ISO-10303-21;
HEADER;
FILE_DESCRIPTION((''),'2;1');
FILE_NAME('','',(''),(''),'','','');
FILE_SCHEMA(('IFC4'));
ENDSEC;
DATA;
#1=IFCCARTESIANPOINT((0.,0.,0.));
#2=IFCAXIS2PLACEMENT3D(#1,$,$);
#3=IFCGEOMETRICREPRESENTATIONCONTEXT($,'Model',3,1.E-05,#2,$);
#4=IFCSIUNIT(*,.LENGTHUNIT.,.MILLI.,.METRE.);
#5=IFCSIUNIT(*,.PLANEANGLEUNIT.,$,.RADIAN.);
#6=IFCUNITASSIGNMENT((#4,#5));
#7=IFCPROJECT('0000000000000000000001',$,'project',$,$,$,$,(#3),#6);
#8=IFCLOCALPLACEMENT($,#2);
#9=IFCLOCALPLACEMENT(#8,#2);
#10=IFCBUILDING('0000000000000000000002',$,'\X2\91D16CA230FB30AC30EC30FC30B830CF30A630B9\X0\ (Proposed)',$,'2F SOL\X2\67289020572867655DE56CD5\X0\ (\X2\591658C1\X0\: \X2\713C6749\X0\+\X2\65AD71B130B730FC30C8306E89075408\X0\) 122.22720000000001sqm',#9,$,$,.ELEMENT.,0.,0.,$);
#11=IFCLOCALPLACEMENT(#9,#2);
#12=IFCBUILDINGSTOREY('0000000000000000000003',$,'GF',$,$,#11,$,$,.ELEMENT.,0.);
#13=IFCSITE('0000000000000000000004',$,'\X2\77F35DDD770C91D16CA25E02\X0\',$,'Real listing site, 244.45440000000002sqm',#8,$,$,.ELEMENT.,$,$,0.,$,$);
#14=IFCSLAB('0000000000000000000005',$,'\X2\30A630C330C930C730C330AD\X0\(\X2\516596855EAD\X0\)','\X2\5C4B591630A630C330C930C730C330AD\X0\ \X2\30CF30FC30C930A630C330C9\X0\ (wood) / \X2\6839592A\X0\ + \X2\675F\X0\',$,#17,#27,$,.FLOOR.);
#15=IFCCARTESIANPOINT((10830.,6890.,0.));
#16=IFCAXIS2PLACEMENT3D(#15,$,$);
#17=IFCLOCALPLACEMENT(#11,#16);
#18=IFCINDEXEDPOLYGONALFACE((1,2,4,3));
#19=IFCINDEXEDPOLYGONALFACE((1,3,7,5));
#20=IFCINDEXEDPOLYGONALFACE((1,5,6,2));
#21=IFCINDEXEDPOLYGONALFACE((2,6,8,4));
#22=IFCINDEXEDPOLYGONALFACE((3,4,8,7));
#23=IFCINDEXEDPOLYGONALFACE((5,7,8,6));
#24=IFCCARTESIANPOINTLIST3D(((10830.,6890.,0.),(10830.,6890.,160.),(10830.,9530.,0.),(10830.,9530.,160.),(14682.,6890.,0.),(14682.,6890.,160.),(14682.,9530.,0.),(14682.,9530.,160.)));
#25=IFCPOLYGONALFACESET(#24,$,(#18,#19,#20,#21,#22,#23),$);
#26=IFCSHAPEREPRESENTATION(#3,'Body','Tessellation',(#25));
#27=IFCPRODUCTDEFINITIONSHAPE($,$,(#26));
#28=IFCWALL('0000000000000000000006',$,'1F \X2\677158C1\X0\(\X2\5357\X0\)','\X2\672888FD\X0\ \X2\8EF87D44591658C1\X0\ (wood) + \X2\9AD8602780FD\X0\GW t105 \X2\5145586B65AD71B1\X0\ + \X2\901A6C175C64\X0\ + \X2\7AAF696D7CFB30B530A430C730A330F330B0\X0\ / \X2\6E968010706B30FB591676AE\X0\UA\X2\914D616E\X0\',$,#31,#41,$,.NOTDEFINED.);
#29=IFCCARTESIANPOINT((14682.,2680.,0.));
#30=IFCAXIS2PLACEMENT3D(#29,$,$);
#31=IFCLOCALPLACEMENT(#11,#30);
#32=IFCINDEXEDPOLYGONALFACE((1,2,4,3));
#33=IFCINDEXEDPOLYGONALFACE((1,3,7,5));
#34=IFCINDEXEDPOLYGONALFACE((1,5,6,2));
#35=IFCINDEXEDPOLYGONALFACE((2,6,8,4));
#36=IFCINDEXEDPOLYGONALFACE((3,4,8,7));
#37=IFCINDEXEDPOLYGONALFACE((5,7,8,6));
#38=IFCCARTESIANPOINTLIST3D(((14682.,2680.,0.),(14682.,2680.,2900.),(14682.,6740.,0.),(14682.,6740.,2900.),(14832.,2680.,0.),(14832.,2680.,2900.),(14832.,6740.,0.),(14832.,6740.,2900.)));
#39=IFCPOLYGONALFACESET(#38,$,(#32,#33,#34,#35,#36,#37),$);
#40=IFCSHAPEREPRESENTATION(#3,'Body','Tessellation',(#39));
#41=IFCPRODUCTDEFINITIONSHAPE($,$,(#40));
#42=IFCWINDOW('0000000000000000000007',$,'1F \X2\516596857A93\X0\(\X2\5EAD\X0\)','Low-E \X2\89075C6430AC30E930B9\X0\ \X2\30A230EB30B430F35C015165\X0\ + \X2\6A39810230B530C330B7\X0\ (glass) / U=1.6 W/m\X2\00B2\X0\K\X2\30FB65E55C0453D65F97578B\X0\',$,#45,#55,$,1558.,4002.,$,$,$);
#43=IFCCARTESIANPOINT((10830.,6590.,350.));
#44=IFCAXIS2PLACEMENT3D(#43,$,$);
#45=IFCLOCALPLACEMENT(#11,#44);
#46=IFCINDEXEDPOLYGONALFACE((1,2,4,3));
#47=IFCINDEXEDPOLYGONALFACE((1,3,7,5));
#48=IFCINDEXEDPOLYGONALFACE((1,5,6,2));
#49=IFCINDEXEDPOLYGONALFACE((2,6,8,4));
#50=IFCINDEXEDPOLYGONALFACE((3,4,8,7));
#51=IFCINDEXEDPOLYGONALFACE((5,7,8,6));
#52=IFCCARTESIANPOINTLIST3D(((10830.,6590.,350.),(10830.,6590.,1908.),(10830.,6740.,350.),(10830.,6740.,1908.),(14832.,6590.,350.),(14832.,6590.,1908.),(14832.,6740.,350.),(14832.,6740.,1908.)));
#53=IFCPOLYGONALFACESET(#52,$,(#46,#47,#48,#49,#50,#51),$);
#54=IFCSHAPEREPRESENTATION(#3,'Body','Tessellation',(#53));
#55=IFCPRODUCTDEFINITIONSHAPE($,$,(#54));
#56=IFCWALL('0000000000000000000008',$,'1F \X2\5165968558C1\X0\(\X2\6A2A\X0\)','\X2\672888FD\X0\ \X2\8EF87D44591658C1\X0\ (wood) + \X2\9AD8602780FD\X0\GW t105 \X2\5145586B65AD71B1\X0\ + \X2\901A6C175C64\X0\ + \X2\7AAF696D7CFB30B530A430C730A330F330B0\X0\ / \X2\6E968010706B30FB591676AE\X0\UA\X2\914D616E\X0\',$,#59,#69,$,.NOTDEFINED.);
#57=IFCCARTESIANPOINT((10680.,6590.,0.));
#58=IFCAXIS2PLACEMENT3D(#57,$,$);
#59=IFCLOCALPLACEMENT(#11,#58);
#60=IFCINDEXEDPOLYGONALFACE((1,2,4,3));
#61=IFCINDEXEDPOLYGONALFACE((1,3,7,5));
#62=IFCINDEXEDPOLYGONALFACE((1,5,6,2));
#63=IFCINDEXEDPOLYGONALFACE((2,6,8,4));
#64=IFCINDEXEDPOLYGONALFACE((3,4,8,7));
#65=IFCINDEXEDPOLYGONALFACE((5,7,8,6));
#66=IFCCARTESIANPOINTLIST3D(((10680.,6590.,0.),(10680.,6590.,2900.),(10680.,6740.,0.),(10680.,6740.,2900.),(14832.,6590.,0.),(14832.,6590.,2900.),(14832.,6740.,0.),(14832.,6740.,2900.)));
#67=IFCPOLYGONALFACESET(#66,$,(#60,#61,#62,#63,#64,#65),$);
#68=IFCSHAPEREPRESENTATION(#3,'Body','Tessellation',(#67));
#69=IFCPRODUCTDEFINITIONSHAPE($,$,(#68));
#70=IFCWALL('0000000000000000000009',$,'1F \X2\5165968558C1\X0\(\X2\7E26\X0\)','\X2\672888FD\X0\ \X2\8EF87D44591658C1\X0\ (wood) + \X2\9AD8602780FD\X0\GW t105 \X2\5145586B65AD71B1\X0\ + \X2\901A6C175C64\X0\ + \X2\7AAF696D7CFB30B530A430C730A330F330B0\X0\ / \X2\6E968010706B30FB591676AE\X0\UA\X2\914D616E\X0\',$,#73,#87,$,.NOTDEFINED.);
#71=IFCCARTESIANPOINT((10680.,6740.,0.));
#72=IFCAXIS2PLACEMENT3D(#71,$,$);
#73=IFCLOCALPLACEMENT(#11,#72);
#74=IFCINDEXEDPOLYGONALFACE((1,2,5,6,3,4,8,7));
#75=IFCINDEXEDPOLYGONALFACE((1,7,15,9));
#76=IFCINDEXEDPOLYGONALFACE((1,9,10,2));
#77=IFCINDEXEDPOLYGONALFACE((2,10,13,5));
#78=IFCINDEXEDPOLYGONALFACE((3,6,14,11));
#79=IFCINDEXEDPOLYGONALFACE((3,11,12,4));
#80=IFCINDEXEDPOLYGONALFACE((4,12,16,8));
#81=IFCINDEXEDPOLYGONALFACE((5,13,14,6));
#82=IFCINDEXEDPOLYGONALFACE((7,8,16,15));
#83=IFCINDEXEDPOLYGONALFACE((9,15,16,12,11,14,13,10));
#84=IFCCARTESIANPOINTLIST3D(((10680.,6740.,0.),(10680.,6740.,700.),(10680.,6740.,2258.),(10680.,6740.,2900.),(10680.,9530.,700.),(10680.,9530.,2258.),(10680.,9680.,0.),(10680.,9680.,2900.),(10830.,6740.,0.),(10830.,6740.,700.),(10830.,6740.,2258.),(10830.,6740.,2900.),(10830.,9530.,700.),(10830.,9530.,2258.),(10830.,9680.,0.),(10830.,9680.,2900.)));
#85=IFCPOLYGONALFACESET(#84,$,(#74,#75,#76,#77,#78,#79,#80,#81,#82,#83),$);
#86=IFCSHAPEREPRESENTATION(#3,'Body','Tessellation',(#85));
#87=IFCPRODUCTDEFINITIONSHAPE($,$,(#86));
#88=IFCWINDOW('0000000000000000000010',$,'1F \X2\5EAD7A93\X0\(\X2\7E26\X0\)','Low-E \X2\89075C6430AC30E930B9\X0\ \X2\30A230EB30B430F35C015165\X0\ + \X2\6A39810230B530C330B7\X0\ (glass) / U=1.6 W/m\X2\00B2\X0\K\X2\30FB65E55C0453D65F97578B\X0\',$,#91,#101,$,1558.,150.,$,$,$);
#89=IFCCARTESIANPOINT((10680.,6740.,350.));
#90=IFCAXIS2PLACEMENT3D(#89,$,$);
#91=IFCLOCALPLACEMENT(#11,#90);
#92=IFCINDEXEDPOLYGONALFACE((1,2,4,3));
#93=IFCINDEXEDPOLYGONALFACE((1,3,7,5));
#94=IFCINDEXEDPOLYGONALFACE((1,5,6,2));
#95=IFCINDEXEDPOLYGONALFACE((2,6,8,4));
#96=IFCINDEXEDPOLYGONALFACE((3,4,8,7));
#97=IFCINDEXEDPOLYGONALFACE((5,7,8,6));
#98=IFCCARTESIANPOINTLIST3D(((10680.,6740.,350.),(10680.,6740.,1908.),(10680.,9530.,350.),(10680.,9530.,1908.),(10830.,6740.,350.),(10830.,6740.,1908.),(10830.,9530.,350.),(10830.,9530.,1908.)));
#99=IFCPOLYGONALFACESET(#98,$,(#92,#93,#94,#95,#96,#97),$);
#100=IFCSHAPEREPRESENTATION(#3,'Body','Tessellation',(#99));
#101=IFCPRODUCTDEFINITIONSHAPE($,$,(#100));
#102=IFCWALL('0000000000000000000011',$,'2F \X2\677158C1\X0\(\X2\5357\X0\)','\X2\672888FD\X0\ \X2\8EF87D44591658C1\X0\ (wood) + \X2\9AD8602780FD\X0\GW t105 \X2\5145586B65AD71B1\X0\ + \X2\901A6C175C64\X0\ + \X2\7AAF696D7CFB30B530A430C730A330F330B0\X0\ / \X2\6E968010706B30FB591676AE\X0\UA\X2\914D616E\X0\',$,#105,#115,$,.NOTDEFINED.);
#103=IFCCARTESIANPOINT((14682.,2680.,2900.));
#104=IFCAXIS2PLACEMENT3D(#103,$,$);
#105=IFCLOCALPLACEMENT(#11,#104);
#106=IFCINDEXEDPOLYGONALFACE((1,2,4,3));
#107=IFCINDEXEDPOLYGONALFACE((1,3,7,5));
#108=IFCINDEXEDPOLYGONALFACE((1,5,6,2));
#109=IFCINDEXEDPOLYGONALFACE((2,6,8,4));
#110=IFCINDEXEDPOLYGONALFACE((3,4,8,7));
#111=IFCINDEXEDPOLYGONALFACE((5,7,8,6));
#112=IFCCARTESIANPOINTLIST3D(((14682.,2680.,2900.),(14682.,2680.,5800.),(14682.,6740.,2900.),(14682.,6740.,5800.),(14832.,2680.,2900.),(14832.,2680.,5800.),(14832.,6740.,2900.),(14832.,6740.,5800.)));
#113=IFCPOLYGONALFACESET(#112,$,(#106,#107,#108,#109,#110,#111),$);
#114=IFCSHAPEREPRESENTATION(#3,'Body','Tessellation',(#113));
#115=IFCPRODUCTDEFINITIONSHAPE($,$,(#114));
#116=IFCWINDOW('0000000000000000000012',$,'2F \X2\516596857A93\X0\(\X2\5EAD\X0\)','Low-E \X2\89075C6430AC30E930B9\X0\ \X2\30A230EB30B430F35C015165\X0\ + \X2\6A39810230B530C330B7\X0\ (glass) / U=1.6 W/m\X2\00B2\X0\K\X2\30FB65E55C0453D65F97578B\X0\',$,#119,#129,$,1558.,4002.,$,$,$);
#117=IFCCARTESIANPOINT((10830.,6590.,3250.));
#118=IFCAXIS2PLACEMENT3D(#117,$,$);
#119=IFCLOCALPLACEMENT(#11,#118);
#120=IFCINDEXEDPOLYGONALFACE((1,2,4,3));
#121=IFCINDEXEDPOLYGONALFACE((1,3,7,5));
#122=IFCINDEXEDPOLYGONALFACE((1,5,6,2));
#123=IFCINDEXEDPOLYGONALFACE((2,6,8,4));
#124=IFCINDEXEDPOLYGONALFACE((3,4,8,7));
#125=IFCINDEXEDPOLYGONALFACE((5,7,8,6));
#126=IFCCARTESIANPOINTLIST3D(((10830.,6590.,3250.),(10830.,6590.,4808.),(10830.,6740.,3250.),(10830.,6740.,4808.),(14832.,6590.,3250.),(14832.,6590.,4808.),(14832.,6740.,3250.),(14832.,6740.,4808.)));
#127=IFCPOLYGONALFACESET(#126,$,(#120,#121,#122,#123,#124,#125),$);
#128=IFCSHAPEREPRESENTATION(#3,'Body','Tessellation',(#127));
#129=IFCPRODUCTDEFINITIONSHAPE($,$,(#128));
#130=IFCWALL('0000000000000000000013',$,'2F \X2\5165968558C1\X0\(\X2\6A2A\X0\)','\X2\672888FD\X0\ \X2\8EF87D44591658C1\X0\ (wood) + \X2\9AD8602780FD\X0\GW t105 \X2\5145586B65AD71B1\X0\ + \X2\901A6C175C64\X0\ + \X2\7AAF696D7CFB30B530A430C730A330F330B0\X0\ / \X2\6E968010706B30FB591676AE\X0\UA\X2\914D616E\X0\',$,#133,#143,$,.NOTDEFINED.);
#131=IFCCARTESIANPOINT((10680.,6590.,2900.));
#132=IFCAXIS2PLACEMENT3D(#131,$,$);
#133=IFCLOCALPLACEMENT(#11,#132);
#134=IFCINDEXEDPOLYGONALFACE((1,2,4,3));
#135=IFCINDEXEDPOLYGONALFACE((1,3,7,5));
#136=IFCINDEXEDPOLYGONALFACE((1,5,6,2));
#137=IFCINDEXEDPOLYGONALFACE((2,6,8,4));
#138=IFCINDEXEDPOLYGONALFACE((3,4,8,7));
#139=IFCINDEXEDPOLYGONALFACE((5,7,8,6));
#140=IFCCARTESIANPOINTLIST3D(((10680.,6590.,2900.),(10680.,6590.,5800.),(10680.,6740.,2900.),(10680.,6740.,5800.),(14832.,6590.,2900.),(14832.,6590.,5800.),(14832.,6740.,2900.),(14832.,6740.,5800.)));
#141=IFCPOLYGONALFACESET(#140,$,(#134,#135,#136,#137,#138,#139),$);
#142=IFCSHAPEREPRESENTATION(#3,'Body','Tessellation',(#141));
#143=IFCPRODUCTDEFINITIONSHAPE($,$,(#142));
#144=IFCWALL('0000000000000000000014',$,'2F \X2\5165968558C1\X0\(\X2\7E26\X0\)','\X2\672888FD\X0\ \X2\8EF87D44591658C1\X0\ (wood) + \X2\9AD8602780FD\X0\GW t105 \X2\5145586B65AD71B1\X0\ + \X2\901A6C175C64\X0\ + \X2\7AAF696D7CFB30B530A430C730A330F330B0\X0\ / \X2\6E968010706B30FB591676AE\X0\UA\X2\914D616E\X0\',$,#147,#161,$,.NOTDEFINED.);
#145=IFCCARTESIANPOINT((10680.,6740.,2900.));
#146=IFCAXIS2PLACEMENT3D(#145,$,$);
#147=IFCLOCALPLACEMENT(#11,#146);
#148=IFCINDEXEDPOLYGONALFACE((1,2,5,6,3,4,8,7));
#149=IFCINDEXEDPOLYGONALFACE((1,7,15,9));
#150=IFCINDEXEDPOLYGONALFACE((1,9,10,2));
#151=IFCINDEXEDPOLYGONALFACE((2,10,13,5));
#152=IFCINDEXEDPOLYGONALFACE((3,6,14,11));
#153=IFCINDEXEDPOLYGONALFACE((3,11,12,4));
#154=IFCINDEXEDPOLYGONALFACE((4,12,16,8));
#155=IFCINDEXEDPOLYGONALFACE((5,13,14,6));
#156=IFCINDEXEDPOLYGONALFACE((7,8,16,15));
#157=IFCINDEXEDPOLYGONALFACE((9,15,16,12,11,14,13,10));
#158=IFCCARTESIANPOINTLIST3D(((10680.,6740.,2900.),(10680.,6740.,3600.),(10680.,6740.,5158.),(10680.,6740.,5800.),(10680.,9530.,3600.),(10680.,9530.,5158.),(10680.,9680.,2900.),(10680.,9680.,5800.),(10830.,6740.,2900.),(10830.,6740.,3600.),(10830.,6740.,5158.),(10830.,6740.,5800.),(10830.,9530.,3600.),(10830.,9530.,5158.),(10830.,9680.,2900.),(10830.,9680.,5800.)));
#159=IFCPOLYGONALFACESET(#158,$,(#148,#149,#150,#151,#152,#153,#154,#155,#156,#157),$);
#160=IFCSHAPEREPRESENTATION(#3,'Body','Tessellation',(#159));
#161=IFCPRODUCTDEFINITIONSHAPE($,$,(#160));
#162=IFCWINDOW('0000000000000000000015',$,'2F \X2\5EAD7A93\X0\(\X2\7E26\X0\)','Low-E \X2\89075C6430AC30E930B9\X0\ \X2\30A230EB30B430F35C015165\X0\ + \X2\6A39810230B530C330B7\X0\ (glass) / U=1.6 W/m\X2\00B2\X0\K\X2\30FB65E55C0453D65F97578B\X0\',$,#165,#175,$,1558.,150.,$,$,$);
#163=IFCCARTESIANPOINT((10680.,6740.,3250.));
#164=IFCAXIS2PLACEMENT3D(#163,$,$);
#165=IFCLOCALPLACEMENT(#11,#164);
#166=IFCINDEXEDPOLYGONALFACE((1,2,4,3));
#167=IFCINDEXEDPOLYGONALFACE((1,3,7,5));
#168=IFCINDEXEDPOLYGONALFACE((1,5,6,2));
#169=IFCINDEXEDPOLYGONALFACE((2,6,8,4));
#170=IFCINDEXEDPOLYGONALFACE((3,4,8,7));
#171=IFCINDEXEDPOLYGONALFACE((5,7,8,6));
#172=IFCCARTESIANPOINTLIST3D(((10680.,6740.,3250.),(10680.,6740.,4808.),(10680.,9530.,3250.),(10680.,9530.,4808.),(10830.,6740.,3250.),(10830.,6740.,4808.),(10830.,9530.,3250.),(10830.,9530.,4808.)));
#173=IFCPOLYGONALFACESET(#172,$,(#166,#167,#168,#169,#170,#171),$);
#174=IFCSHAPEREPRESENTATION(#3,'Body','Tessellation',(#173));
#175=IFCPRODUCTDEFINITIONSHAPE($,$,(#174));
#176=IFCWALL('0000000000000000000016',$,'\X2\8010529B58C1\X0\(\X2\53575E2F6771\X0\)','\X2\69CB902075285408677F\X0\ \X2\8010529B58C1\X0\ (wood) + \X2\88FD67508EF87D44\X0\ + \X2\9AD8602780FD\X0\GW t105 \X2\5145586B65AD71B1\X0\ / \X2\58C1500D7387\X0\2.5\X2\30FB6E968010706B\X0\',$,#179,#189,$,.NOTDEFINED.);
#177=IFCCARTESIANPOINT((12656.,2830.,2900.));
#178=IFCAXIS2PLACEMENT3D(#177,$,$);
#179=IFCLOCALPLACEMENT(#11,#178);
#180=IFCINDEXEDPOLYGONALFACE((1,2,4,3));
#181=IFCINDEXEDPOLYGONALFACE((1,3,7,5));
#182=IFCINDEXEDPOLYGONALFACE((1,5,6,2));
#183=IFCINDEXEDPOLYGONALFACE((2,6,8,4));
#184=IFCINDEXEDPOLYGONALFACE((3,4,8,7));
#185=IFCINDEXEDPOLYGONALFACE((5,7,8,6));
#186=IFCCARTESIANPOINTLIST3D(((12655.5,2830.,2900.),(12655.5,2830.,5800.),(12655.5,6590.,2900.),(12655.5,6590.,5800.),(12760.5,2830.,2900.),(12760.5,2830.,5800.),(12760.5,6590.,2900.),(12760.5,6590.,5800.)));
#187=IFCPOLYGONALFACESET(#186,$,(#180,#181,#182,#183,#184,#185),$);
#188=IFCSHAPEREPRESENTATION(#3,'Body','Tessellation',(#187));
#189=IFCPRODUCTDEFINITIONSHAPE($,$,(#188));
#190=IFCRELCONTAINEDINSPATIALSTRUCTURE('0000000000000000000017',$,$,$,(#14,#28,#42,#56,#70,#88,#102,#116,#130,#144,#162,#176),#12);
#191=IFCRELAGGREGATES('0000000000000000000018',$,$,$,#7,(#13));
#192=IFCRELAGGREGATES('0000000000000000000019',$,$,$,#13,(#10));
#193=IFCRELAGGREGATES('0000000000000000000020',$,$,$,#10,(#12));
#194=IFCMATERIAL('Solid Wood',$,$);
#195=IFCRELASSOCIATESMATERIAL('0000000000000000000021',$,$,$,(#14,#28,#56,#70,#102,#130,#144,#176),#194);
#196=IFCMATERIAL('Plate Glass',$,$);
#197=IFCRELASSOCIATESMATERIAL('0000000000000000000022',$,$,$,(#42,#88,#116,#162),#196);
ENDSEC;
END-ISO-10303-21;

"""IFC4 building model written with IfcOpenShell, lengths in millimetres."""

from ifc_helpers import new_model, si_unit, frame, frame_2d, origin, place, context, project, spatial, rectangle, extrude, material, element, fill, save


model = new_model("IFC4")

# Units and contexts
model_context = context("Model", 3, precision=1e-05, world=origin())
ifc_project = project(units=[si_unit("LENGTHUNIT", "METRE", prefix="MILLI"), si_unit("PLANEANGLEUNIT", "RADIAN")], contexts=[model_context])

# Site, building, storey
site_placement = place(None, origin())
site = spatial("IfcSite", under=ifc_project, at=site_placement, Name="石川県金沢市", ObjectType="Real listing site, 244.45440000000002sqm", CompositionType="ELEMENT", RefElevation=0.0)
building_placement = place(site_placement, origin())
building = spatial("IfcBuilding", under=site, at=building_placement, Name="金沢・ガレージハウス (Proposed)", ObjectType="2F SOL木造在来工法 (外壁: 焼杉+断熱シートの複合) 122.22720000000001sqm", CompositionType="ELEMENT", ElevationOfRefHeight=0.0, ElevationOfTerrain=0.0)
storey_placement = place(building_placement, origin())
storey = spatial("IfcBuildingStorey", under=building, at=storey_placement, Name="GF", CompositionType="ELEMENT", Elevation=0.0)

# Slab
ifc_material_1 = material(Name="Solid Wood")
slab_placement = place(storey_placement, frame((10830.0, 6890.0, 0.0)))
element("IfcSlab", 1, at=slab_placement, inside=storey, material=ifc_material_1, Name="ウッドデッキ(入隅庭)", Description="屋外ウッドデッキ ハードウッド (wood) / 根太 + 束", PredefinedType="FLOOR", context=model_context, shape_type="SweptSolid", body=[
    extrude(rectangle(XDim=3852.0, YDim=2640.0, at=frame_2d((1926.0, 1320.0))), frame((10830.0, 6890.0, 0.0)), (0.0, 0.0, 1.0), 160.0),
])

# Wall, opening, window
wall_1_placement = place(storey_placement, frame((14682.0, 2680.0, 0.0)))
wall_1 = element("IfcWall", 2, at=wall_1_placement, inside=storey, material=ifc_material_1, Name="1F 東壁(南)", Description="木製 軸組外壁 (wood) + 高性能GW t105 充填断熱 + 通気層 + 窯業系サイディング / 準耐火・外皮UA配慮", PredefinedType="NOTDEFINED", context=model_context, shape_type="SweptSolid", body=[
    extrude(rectangle(XDim=150.0, YDim=4060.0, at=frame_2d((75.0, 2030.0))), frame((14682.0, 2680.0, 0.0)), (0.0, 0.0, 1.0), 2900.0),
])
opening_1_placement = place(storey_placement, frame((10830.0, 6590.0, 350.0)))
opening_1 = element("IfcOpeningElement", 3, at=opening_1_placement, cuts=wall_1, PredefinedType="NOTDEFINED", context=model_context, shape_type="SweptSolid", body=[
    extrude(rectangle(XDim=4002.0, YDim=150.0, at=frame_2d((2001.0, 75.0))), frame((10830.0, 6590.0, 350.0)), (0.0, 0.0, 1.0), 1558.0),
])
ifc_material_2 = material(Name="Plate Glass")
window_1_placement = place(storey_placement, frame((10830.0, 6590.0, 350.0)))
window_1 = element("IfcWindow", 4, at=window_1_placement, inside=storey, material=ifc_material_2, Name="1F 入隅窓(庭)", Description="Low-E 複層ガラス アルゴン封入 + 樹脂サッシ (glass) / U=1.6 W/m²K・日射取得型", OverallHeight=1558.0, OverallWidth=4002.0, context=model_context, shape_type="SweptSolid", body=[
    extrude(rectangle(XDim=4002.0, YDim=150.0, at=frame_2d((2001.0, 75.0))), frame((10830.0, 6590.0, 350.0)), (0.0, 0.0, 1.0), 1558.0),
])
fill(opening_1, window_1)

# Wall
wall_2_placement = place(storey_placement, frame((10680.0, 6590.0, 0.0)))
element("IfcWall", 5, at=wall_2_placement, inside=storey, material=ifc_material_1, Name="1F 入隅壁(横)", Description="木製 軸組外壁 (wood) + 高性能GW t105 充填断熱 + 通気層 + 窯業系サイディング / 準耐火・外皮UA配慮", PredefinedType="NOTDEFINED", context=model_context, shape_type="SweptSolid", body=[
    extrude(rectangle(XDim=4152.0, YDim=150.0, at=frame_2d((2076.0, 75.0))), frame((10680.0, 6590.0, 0.0)), (0.0, 0.0, 1.0), 2900.0),
])

# Wall, opening, window
wall_3_placement = place(storey_placement, frame((10680.0, 6740.0, 0.0)))
wall_3 = element("IfcWall", 6, at=wall_3_placement, inside=storey, material=ifc_material_1, Name="1F 入隅壁(縦)", Description="木製 軸組外壁 (wood) + 高性能GW t105 充填断熱 + 通気層 + 窯業系サイディング / 準耐火・外皮UA配慮", PredefinedType="NOTDEFINED", context=model_context, shape_type="SweptSolid", body=[
    extrude(rectangle(XDim=150.0, YDim=2940.0, at=frame_2d((75.0, 1470.0))), frame((10680.0, 6740.0, 0.0)), (0.0, 0.0, 1.0), 2900.0),
])
opening_2_placement = place(storey_placement, frame((10680.0, 6740.0, 350.0)))
opening_2 = element("IfcOpeningElement", 7, at=opening_2_placement, cuts=wall_3, PredefinedType="NOTDEFINED", context=model_context, shape_type="SweptSolid", body=[
    extrude(rectangle(XDim=150.0, YDim=2790.0, at=frame_2d((75.0, 1395.0))), frame((10680.0, 6740.0, 350.0)), (0.0, 0.0, 1.0), 1558.0),
])
window_2_placement = place(storey_placement, frame((10680.0, 6740.0, 350.0)))
window_2 = element("IfcWindow", 8, at=window_2_placement, inside=storey, material=ifc_material_2, Name="1F 庭窓(縦)", Description="Low-E 複層ガラス アルゴン封入 + 樹脂サッシ (glass) / U=1.6 W/m²K・日射取得型", OverallHeight=1558.0, OverallWidth=150.0, context=model_context, shape_type="SweptSolid", body=[
    extrude(rectangle(XDim=150.0, YDim=2790.0, at=frame_2d((75.0, 1395.0))), frame((10680.0, 6740.0, 350.0)), (0.0, 0.0, 1.0), 1558.0),
])
fill(opening_2, window_2)

# Wall, opening, window
wall_4_placement = place(storey_placement, frame((14682.0, 2680.0, 2900.0)))
wall_4 = element("IfcWall", 9, at=wall_4_placement, inside=storey, material=ifc_material_1, Name="2F 東壁(南)", Description="木製 軸組外壁 (wood) + 高性能GW t105 充填断熱 + 通気層 + 窯業系サイディング / 準耐火・外皮UA配慮", PredefinedType="NOTDEFINED", context=model_context, shape_type="SweptSolid", body=[
    extrude(rectangle(XDim=150.0, YDim=4060.0, at=frame_2d((75.0, 2030.0))), frame((14682.0, 2680.0, 2900.0)), (0.0, 0.0, 1.0), 2900.0),
])
opening_3_placement = place(storey_placement, frame((10830.0, 6590.0, 3250.0)))
opening_3 = element("IfcOpeningElement", 10, at=opening_3_placement, cuts=wall_4, PredefinedType="NOTDEFINED", context=model_context, shape_type="SweptSolid", body=[
    extrude(rectangle(XDim=4002.0, YDim=150.0, at=frame_2d((2001.0, 75.0))), frame((10830.0, 6590.0, 3250.0)), (0.0, 0.0, 1.0), 1558.0),
])
window_3_placement = place(storey_placement, frame((10830.0, 6590.0, 3250.0)))
window_3 = element("IfcWindow", 11, at=window_3_placement, inside=storey, material=ifc_material_2, Name="2F 入隅窓(庭)", Description="Low-E 複層ガラス アルゴン封入 + 樹脂サッシ (glass) / U=1.6 W/m²K・日射取得型", OverallHeight=1558.0, OverallWidth=4002.0, context=model_context, shape_type="SweptSolid", body=[
    extrude(rectangle(XDim=4002.0, YDim=150.0, at=frame_2d((2001.0, 75.0))), frame((10830.0, 6590.0, 3250.0)), (0.0, 0.0, 1.0), 1558.0),
])
fill(opening_3, window_3)

# Wall
wall_5_placement = place(storey_placement, frame((10680.0, 6590.0, 2900.0)))
element("IfcWall", 12, at=wall_5_placement, inside=storey, material=ifc_material_1, Name="2F 入隅壁(横)", Description="木製 軸組外壁 (wood) + 高性能GW t105 充填断熱 + 通気層 + 窯業系サイディング / 準耐火・外皮UA配慮", PredefinedType="NOTDEFINED", context=model_context, shape_type="SweptSolid", body=[
    extrude(rectangle(XDim=4152.0, YDim=150.0, at=frame_2d((2076.0, 75.0))), frame((10680.0, 6590.0, 2900.0)), (0.0, 0.0, 1.0), 2900.0),
])

# Wall, opening, window
wall_6_placement = place(storey_placement, frame((10680.0, 6740.0, 2900.0)))
wall_6 = element("IfcWall", 13, at=wall_6_placement, inside=storey, material=ifc_material_1, Name="2F 入隅壁(縦)", Description="木製 軸組外壁 (wood) + 高性能GW t105 充填断熱 + 通気層 + 窯業系サイディング / 準耐火・外皮UA配慮", PredefinedType="NOTDEFINED", context=model_context, shape_type="SweptSolid", body=[
    extrude(rectangle(XDim=150.0, YDim=2940.0, at=frame_2d((75.0, 1470.0))), frame((10680.0, 6740.0, 2900.0)), (0.0, 0.0, 1.0), 2900.0),
])
opening_4_placement = place(storey_placement, frame((10680.0, 6740.0, 3250.0)))
opening_4 = element("IfcOpeningElement", 14, at=opening_4_placement, cuts=wall_6, PredefinedType="NOTDEFINED", context=model_context, shape_type="SweptSolid", body=[
    extrude(rectangle(XDim=150.0, YDim=2790.0, at=frame_2d((75.0, 1395.0))), frame((10680.0, 6740.0, 3250.0)), (0.0, 0.0, 1.0), 1558.0),
])
window_4_placement = place(storey_placement, frame((10680.0, 6740.0, 3250.0)))
window_4 = element("IfcWindow", 15, at=window_4_placement, inside=storey, material=ifc_material_2, Name="2F 庭窓(縦)", Description="Low-E 複層ガラス アルゴン封入 + 樹脂サッシ (glass) / U=1.6 W/m²K・日射取得型", OverallHeight=1558.0, OverallWidth=150.0, context=model_context, shape_type="SweptSolid", body=[
    extrude(rectangle(XDim=150.0, YDim=2790.0, at=frame_2d((75.0, 1395.0))), frame((10680.0, 6740.0, 3250.0)), (0.0, 0.0, 1.0), 1558.0),
])
fill(opening_4, window_4)

# Wall
wall_7_placement = place(storey_placement, frame((12656.0, 2830.0, 2900.0)))
element("IfcWall", 16, at=wall_7_placement, inside=storey, material=ifc_material_1, Name="耐力壁(南帯東)", Description="構造用合板 耐力壁 (wood) + 製材軸組 + 高性能GW t105 充填断熱 / 壁倍率2.5・準耐火", PredefinedType="NOTDEFINED", context=model_context, shape_type="SweptSolid", body=[
    extrude(rectangle(XDim=105.0, YDim=3760.0, at=frame_2d((52.0, 1880.0))), frame((12656.0, 2830.0, 2900.0)), (0.0, 0.0, 1.0), 2900.0),
])

save(model, "model.ifc")
